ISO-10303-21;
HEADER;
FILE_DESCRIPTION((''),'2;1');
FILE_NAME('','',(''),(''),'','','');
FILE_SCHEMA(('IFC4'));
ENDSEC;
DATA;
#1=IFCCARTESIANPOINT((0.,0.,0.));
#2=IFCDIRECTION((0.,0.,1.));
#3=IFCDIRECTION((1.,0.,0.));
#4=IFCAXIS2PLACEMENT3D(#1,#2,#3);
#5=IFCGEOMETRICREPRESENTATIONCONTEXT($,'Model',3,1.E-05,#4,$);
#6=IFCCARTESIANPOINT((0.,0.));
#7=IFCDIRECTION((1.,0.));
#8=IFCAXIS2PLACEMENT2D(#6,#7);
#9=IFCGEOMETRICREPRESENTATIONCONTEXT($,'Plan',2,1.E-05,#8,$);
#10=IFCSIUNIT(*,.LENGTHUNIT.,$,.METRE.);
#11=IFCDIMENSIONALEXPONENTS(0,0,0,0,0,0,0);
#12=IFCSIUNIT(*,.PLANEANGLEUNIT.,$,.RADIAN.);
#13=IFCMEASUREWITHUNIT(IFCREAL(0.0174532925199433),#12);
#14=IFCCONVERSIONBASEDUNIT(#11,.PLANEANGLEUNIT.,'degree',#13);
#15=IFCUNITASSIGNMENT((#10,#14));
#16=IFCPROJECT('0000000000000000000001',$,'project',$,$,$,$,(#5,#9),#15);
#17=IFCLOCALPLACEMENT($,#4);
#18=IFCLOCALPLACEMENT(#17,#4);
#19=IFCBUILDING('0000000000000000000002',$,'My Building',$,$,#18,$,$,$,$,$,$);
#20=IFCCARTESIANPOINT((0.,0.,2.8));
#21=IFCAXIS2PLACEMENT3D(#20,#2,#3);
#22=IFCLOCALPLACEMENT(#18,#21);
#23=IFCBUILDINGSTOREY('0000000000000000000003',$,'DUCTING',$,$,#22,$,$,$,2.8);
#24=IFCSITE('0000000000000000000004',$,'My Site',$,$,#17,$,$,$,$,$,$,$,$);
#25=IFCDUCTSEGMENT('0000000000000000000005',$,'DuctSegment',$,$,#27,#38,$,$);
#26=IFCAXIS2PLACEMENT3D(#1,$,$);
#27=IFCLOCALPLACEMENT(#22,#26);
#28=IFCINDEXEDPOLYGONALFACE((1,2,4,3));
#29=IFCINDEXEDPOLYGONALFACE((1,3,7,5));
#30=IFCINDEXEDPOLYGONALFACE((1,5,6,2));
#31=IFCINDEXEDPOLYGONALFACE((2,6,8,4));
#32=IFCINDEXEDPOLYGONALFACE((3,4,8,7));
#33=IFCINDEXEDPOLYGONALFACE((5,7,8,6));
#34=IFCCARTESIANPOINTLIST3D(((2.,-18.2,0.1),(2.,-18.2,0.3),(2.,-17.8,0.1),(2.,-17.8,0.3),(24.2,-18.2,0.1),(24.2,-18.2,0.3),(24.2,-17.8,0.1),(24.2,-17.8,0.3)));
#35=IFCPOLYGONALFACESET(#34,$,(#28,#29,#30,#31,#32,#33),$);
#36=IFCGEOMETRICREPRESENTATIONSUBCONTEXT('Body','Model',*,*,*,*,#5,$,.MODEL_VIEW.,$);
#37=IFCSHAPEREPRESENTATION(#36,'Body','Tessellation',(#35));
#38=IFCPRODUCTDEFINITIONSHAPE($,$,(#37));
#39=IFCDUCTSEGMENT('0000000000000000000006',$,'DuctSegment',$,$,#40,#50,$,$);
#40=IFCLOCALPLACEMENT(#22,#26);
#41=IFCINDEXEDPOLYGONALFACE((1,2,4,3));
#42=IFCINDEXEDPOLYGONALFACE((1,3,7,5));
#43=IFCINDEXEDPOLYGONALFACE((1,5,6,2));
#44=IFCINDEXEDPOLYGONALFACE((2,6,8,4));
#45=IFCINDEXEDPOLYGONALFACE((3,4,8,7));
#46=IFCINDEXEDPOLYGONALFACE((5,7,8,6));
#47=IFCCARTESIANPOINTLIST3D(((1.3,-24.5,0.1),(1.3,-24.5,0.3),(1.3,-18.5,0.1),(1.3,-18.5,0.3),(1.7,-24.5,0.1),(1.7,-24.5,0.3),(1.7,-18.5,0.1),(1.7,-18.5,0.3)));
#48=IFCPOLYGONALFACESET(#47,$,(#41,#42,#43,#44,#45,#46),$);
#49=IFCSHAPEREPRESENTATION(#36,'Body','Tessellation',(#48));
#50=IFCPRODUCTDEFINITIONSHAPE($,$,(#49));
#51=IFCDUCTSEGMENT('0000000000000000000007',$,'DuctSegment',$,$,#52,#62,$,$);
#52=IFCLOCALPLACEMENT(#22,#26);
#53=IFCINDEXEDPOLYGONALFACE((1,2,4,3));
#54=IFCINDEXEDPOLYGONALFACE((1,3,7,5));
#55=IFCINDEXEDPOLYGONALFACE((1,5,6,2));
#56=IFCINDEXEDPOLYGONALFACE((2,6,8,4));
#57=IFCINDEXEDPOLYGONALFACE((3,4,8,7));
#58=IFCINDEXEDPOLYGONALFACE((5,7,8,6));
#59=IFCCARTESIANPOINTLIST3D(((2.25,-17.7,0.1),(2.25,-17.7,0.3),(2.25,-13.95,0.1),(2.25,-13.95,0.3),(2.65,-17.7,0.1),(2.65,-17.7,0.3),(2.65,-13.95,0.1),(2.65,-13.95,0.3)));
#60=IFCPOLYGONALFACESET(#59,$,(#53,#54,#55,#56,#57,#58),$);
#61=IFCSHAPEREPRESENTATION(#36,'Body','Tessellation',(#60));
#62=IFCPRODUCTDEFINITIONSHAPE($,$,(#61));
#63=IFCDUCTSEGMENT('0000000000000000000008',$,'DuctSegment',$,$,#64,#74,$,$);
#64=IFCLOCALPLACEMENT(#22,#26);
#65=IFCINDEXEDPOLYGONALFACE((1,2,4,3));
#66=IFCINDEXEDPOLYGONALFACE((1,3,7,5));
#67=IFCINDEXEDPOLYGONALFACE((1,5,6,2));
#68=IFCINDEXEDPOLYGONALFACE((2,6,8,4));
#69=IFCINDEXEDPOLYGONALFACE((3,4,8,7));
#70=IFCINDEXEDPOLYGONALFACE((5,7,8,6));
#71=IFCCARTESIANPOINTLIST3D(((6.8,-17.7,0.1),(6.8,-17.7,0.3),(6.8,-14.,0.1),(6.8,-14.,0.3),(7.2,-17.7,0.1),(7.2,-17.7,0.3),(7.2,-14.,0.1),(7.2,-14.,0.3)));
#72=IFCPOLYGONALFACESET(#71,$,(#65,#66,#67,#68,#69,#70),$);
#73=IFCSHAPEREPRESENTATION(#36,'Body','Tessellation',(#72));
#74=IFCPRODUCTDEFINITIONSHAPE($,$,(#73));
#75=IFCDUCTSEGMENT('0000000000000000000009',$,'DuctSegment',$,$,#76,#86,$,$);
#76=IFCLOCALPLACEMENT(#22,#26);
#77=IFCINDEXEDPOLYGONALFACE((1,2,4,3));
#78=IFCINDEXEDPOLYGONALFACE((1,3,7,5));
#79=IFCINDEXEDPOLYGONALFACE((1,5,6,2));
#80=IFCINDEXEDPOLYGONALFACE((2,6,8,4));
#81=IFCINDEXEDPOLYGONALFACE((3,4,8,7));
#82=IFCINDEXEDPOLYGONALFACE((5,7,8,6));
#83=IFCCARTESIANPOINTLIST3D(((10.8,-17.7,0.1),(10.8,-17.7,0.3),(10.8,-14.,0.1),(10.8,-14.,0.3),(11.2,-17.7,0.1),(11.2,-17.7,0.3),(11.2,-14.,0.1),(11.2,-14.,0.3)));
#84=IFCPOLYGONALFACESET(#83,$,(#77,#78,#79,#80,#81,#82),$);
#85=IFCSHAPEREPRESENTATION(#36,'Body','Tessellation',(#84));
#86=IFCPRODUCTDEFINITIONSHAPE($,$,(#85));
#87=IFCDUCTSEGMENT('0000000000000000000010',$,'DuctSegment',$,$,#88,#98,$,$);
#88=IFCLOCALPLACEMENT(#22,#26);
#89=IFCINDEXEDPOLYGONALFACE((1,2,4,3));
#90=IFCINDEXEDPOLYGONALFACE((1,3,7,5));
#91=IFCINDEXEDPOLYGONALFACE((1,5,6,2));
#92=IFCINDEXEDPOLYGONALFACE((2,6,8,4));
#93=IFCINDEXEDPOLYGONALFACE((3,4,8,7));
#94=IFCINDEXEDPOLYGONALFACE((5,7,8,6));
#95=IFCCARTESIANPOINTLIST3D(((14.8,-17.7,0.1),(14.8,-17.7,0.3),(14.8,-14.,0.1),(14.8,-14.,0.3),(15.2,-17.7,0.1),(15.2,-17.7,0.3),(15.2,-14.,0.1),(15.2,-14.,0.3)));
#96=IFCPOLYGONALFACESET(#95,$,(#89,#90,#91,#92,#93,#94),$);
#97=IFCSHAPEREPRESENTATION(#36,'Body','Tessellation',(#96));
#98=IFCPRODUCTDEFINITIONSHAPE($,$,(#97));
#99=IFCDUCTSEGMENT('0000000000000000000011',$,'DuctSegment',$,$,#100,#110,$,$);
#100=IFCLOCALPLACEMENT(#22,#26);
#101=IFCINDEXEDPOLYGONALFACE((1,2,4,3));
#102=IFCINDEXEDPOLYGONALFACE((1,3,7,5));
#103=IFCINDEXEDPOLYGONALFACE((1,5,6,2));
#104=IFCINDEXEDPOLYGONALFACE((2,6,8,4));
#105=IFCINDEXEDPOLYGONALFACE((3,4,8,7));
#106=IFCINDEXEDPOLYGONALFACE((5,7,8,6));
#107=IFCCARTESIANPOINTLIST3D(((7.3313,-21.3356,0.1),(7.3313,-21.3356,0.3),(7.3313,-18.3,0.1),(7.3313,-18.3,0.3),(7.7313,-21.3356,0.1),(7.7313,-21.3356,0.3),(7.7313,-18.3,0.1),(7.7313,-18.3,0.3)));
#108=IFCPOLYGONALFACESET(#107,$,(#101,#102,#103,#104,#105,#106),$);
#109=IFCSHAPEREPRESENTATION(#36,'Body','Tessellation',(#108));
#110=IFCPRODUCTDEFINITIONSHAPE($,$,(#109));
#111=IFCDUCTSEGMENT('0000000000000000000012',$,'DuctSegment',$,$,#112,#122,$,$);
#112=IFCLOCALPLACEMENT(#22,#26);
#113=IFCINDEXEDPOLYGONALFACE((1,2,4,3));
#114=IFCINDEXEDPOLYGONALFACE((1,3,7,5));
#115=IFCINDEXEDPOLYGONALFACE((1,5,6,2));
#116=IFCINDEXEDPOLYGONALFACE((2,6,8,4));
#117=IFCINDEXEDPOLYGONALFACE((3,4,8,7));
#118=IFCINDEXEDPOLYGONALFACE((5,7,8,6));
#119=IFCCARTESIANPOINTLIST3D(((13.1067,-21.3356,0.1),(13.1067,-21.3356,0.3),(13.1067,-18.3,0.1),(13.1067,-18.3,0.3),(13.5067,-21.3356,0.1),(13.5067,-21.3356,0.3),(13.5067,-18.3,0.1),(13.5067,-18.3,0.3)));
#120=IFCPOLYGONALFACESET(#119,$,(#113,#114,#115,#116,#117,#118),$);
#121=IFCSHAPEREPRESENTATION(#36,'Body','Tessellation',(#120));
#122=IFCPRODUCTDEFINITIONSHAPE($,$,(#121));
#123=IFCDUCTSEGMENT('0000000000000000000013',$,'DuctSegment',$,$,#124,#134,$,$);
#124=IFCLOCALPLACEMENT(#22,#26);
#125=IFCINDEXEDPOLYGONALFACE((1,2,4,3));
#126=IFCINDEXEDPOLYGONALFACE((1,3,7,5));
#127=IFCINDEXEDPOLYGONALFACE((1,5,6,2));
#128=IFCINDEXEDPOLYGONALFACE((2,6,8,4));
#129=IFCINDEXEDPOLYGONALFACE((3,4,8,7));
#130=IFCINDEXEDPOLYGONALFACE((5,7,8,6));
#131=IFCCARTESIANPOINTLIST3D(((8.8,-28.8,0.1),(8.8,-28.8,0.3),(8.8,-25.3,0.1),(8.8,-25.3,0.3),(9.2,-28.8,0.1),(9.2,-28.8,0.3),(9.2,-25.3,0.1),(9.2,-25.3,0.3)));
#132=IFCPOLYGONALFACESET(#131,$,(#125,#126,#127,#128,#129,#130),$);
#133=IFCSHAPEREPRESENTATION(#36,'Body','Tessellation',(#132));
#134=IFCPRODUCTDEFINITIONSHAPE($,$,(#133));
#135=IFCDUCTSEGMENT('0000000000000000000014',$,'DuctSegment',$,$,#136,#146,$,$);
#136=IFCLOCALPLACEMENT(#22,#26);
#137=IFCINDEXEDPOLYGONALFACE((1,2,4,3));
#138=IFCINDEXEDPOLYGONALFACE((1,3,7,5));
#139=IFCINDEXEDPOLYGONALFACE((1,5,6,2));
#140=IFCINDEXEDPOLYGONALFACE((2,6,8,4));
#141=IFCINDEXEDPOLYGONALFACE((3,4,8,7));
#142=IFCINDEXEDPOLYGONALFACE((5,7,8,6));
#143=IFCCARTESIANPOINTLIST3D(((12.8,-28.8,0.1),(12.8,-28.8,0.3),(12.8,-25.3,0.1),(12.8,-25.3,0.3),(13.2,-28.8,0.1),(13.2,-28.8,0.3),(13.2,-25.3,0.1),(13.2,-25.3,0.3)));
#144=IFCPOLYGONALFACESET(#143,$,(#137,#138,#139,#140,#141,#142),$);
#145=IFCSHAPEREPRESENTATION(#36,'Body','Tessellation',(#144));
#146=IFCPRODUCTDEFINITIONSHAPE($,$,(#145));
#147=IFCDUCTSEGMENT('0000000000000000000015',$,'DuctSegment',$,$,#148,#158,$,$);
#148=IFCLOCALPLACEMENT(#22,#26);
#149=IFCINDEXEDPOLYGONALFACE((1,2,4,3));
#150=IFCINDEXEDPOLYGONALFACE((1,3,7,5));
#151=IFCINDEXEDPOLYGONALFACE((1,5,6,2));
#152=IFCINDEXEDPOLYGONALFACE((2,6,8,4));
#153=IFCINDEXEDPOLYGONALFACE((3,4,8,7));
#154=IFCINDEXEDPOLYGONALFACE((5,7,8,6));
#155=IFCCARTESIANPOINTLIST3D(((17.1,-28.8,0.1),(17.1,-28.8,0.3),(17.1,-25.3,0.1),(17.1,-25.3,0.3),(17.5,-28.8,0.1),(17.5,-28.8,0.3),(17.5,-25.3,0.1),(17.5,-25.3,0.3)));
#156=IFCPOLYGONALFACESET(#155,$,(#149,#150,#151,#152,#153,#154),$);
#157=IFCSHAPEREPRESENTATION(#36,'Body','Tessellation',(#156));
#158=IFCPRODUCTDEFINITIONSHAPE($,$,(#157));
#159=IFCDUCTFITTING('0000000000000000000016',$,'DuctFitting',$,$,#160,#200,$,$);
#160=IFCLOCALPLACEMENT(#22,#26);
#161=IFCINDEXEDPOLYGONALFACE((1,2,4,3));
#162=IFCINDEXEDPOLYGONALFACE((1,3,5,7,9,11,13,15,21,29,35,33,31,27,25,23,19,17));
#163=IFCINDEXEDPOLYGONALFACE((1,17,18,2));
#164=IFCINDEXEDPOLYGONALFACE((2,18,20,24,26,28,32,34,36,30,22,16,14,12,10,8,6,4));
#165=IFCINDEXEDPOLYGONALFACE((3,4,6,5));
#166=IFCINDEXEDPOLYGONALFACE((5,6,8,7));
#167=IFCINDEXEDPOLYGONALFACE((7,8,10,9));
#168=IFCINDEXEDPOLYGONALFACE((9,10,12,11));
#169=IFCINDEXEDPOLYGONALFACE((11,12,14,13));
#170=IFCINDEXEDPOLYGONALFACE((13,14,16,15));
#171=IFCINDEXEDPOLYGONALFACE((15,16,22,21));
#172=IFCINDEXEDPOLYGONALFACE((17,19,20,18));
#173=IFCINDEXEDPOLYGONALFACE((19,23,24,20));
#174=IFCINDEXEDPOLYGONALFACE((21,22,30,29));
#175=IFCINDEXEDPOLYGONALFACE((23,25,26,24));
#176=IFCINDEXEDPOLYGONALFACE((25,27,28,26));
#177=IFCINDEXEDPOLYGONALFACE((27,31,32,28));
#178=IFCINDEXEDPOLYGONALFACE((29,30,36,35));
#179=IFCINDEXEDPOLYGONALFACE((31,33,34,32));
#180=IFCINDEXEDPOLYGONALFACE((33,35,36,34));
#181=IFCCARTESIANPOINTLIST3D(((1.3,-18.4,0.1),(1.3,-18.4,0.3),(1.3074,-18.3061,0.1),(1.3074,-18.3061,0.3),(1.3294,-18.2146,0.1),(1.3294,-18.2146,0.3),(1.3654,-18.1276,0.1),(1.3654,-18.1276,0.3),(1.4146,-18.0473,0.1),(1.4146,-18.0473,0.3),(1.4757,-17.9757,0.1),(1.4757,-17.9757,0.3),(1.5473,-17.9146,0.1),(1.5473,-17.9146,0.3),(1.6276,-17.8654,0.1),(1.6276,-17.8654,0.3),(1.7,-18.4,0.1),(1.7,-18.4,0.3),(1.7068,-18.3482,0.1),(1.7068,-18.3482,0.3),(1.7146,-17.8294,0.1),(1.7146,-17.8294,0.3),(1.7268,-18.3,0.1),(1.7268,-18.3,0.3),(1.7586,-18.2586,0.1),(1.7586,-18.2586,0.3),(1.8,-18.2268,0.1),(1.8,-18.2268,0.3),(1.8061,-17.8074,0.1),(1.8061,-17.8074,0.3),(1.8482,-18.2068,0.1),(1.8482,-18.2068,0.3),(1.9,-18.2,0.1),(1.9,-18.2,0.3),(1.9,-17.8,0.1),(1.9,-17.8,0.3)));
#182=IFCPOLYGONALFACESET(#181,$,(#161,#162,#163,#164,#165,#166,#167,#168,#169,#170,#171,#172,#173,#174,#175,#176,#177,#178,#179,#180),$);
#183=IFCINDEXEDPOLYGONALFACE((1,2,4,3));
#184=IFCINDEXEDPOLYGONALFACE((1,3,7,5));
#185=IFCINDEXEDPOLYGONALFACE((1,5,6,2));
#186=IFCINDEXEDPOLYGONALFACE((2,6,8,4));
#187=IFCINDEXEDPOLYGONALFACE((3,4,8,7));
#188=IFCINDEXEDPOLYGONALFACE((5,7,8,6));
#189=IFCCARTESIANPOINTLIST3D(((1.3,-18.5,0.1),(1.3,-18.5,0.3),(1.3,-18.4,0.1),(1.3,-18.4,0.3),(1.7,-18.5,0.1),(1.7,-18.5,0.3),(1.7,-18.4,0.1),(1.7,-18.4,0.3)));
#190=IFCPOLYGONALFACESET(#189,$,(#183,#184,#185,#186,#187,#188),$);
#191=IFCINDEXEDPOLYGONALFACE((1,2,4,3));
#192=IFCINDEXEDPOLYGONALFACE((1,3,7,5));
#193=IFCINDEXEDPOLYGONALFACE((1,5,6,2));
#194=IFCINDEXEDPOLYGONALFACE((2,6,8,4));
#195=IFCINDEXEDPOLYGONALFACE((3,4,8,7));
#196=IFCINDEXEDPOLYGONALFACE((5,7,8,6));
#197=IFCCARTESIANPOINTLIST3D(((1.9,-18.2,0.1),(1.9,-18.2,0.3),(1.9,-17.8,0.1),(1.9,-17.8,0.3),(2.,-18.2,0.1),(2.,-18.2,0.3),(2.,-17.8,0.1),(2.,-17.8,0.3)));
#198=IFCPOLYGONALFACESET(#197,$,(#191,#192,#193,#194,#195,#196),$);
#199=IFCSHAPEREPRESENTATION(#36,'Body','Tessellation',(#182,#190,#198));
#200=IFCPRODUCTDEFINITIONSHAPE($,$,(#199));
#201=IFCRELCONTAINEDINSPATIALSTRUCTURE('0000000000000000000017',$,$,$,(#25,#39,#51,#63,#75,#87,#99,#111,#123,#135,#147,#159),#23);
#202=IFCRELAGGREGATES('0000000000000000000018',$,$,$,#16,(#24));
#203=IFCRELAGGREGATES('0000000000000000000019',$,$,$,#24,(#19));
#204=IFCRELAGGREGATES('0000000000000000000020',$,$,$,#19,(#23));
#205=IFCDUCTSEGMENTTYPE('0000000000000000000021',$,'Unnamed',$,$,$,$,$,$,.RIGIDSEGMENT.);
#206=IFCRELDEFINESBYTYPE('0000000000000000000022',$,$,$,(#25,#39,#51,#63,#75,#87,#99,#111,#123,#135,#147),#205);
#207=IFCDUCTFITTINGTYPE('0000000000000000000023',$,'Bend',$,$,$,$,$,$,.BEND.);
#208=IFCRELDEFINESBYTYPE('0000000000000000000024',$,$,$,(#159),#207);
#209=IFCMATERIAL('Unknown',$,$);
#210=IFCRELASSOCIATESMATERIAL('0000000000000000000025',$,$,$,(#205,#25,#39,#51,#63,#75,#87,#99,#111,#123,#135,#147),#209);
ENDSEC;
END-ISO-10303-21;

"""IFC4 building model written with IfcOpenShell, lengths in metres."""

from ifc_helpers import new_model, entity, si_unit, converted_unit, frame, origin_with_axes, origin_2d_with_axis, place, context, subcontext, project, spatial, line, arc, indexed_curve, rectangle, outline, extrude, source, transform, mapped, material, material_profile, profile_set, profile_usage, type_object, type_shapes, element, save


model = new_model("IFC4")

# Units and contexts
model_context = context("Model", 3, precision=1e-05, world=origin_with_axes())
plan_context = context("Plan", 2, precision=1e-05, world=origin_2d_with_axis())
body_context = subcontext(model_context, "Body", "Model", "MODEL_VIEW")
ifc_project = project(units=[si_unit("LENGTHUNIT", "METRE"), converted_unit("PLANEANGLEUNIT", "degree", entity("IfcReal", 0.0174532925199433), si_unit("PLANEANGLEUNIT", "RADIAN"), dimensions=[0, 0, 0, 0, 0, 0, 0])], contexts=[model_context, plan_context])

# Site, building, storey
site_placement = place(None, origin_with_axes())
site = spatial("IfcSite", under=ifc_project, at=site_placement, Name="My Site")
building_placement = place(site_placement, origin_with_axes())
building = spatial("IfcBuilding", under=site, at=building_placement, Name="My Building")
storey_placement = place(building_placement, frame((0.0, 0.0, 2.8), z_axis=(0.0, 0.0, 1.0), x_axis=(1.0, 0.0, 0.0)))
storey = spatial("IfcBuildingStorey", under=building, at=storey_placement, Name="DUCTING", Elevation=2.8)

# Duct segments
ifc_material = material(Name="Unknown")
ifc_material_profile = material_profile(ifc_material, rectangle(XDim=0.4, YDim=0.2))
ifc_profile_set = profile_set([ifc_material_profile])
ifc_profile_usage_1 = profile_usage(ifc_profile_set)
duct_segment_type = type_object("IfcDuctSegmentType", Name="Unnamed", PredefinedType="RIGIDSEGMENT", material=ifc_profile_set)
duct_segment_1_placement = place(storey_placement, frame((2.0, -18.0, 0.2), z_axis=(1.0, 0.0, 0.0), x_axis=(0.0, 1.0, 0.0)))
element("IfcDuctSegment", 1, at=duct_segment_1_placement, inside=storey, type_object=duct_segment_type, material=ifc_profile_usage_1, Name="DuctSegment", context=body_context, shape_type="SweptSolid", body=[
    extrude(rectangle(XDim=0.4, YDim=0.2), origin_with_axes(), (0.0, 0.0, 1.0), 22.2),
])
ifc_profile_usage_2 = profile_usage(ifc_profile_set)
duct_segment_2_placement = place(storey_placement, frame((1.5, -24.5, 0.2), z_axis=(0.0, 1.0, 0.0), x_axis=(-1.0, 0.0, 0.0)))
element("IfcDuctSegment", 2, at=duct_segment_2_placement, inside=storey, type_object=duct_segment_type, material=ifc_profile_usage_2, Name="DuctSegment", context=body_context, shape_type="SweptSolid", body=[
    extrude(rectangle(XDim=0.4, YDim=0.2), origin_with_axes(), (0.0, 0.0, 1.0), 6.0),
])
ifc_profile_usage_3 = profile_usage(ifc_profile_set)
duct_segment_3_placement = place(storey_placement, frame((2.45, -17.7, 0.2), z_axis=(0.0, 1.0, 0.0), x_axis=(-1.0, 0.0, 0.0)))
element("IfcDuctSegment", 3, at=duct_segment_3_placement, inside=storey, type_object=duct_segment_type, material=ifc_profile_usage_3, Name="DuctSegment", context=body_context, shape_type="SweptSolid", body=[
    extrude(rectangle(XDim=0.4, YDim=0.2), origin_with_axes(), (0.0, 0.0, 1.0), 3.75),
])
ifc_profile_usage_4 = profile_usage(ifc_profile_set)
duct_segment_4_placement = place(storey_placement, frame((7.0, -17.7, 0.2), z_axis=(0.0, 1.0, 0.0), x_axis=(-1.0, 0.0, 0.0)))
element("IfcDuctSegment", 4, at=duct_segment_4_placement, inside=storey, type_object=duct_segment_type, material=ifc_profile_usage_4, Name="DuctSegment", context=body_context, shape_type="SweptSolid", body=[
    extrude(rectangle(XDim=0.4, YDim=0.2), origin_with_axes(), (0.0, 0.0, 1.0), 3.7),
])
ifc_profile_usage_5 = profile_usage(ifc_profile_set)
duct_segment_5_placement = place(storey_placement, frame((11.0, -17.7, 0.2), z_axis=(0.0, 1.0, 0.0), x_axis=(-1.0, 0.0, 0.0)))
element("IfcDuctSegment", 5, at=duct_segment_5_placement, inside=storey, type_object=duct_segment_type, material=ifc_profile_usage_5, Name="DuctSegment", context=body_context, shape_type="SweptSolid", body=[
    extrude(rectangle(XDim=0.4, YDim=0.2), origin_with_axes(), (0.0, 0.0, 1.0), 3.7),
])
ifc_profile_usage_6 = profile_usage(ifc_profile_set)
duct_segment_6_placement = place(storey_placement, frame((15.0, -17.7, 0.2), z_axis=(0.0, 1.0, 0.0), x_axis=(-1.0, 0.0, 0.0)))
element("IfcDuctSegment", 6, at=duct_segment_6_placement, inside=storey, type_object=duct_segment_type, material=ifc_profile_usage_6, Name="DuctSegment", context=body_context, shape_type="SweptSolid", body=[
    extrude(rectangle(XDim=0.4, YDim=0.2), origin_with_axes(), (0.0, 0.0, 1.0), 3.7),
])
ifc_profile_usage_7 = profile_usage(ifc_profile_set)
duct_segment_7_placement = place(storey_placement, frame((7.5313, -18.3, 0.2), z_axis=(0.0, -1.0, 0.0), x_axis=(1.0, 0.0, 0.0)))
element("IfcDuctSegment", 7, at=duct_segment_7_placement, inside=storey, type_object=duct_segment_type, material=ifc_profile_usage_7, Name="DuctSegment", context=body_context, shape_type="SweptSolid", body=[
    extrude(rectangle(XDim=0.4, YDim=0.2), origin_with_axes(), (0.0, 0.0, 1.0), 3.0356),
])
ifc_profile_usage_8 = profile_usage(ifc_profile_set)
duct_segment_8_placement = place(storey_placement, frame((13.3067, -18.3, 0.2), z_axis=(0.0, -1.0, 0.0), x_axis=(1.0, 0.0, 0.0)))
element("IfcDuctSegment", 8, at=duct_segment_8_placement, inside=storey, type_object=duct_segment_type, material=ifc_profile_usage_8, Name="DuctSegment", context=body_context, shape_type="SweptSolid", body=[
    extrude(rectangle(XDim=0.4, YDim=0.2), origin_with_axes(), (0.0, 0.0, 1.0), 3.0356),
])
ifc_profile_usage_9 = profile_usage(ifc_profile_set)
duct_segment_9_placement = place(storey_placement, frame((9.0, -25.3, 0.2), z_axis=(0.0, -1.0, 0.0), x_axis=(1.0, 0.0, 0.0)))
element("IfcDuctSegment", 9, at=duct_segment_9_placement, inside=storey, type_object=duct_segment_type, material=ifc_profile_usage_9, Name="DuctSegment", context=body_context, shape_type="SweptSolid", body=[
    extrude(rectangle(XDim=0.4, YDim=0.2), origin_with_axes(), (0.0, 0.0, 1.0), 3.5),
])
ifc_profile_usage_10 = profile_usage(ifc_profile_set)
duct_segment_10_placement = place(storey_placement, frame((13.0, -25.3, 0.2), z_axis=(0.0, -1.0, 0.0), x_axis=(1.0, 0.0, 0.0)))
element("IfcDuctSegment", 10, at=duct_segment_10_placement, inside=storey, type_object=duct_segment_type, material=ifc_profile_usage_10, Name="DuctSegment", context=body_context, shape_type="SweptSolid", body=[
    extrude(rectangle(XDim=0.4, YDim=0.2), origin_with_axes(), (0.0, 0.0, 1.0), 3.5),
])
ifc_profile_usage_11 = profile_usage(ifc_profile_set)
duct_segment_11_placement = place(storey_placement, frame((17.3, -25.3, 0.2), z_axis=(0.0, -1.0, 0.0), x_axis=(1.0, 0.0, 0.0)))
element("IfcDuctSegment", 11, at=duct_segment_11_placement, inside=storey, type_object=duct_segment_type, material=ifc_profile_usage_11, Name="DuctSegment", context=body_context, shape_type="SweptSolid", body=[
    extrude(rectangle(XDim=0.4, YDim=0.2), origin_with_axes(), (0.0, 0.0, 1.0), 3.5),
])

# Duct fitting
duct_fitting_type_1 = type_object("IfcDuctFittingType", Name="Bend", PredefinedType="BEND")
shared_shape = source(origin_with_axes(), body_context, "Body", "SweptSolid", [
    extrude(outline(indexed_curve([(-0.2, 0.0), (-0.2586, 0.1414), (-0.4, 0.2), (-0.4, 0.6), (0.0243, 0.4243), (0.2, 0.0)], segments=[arc(1, 2, 3), line(3, 4), arc(4, 5, 6), line(6, 1)])), frame((0.0, -0.1, 0.1), z_axis=(0.0, -1.0, 0.0), x_axis=(1.0, 0.0, 0.0)), (0.0, 0.0, -1.0), 0.2),
    extrude(rectangle(XDim=0.4, YDim=0.2), origin_with_axes(), (0.0, 0.0, 1.0), 0.1),
    extrude(rectangle(XDim=0.4, YDim=0.2), frame((-0.4, 0.0, 0.5), z_axis=(-1.0, 0.0, 0.0), x_axis=(0.0, 0.0, -1.0)), (0.0, 0.0, 1.0), 0.1),
])
type_shapes(duct_fitting_type_1, [shared_shape])
for number, where, z_axis, x_axis, name in (
    (12, (1.5, -18.5, 0.2), (0.0, 1.0, 0.0), (-1.0, 0.0, 0.0), "DuctFitting"),
):
    element("IfcDuctFitting", number, at=place(storey_placement, frame(where, z_axis=z_axis, x_axis=x_axis)), inside=storey, type_object=duct_fitting_type_1, Name=name, context=body_context, shape_type="MappedRepresentation", body=[
        mapped(shared_shape, transform((0.0, 0.0, 0.0), x_axis=(1.0, 0.0, 0.0), y_axis=(0.0, 1.0, 0.0), z_axis=(0.0, 0.0, 1.0), scale=1.0)),
    ])

save(model, "model.ifc")
